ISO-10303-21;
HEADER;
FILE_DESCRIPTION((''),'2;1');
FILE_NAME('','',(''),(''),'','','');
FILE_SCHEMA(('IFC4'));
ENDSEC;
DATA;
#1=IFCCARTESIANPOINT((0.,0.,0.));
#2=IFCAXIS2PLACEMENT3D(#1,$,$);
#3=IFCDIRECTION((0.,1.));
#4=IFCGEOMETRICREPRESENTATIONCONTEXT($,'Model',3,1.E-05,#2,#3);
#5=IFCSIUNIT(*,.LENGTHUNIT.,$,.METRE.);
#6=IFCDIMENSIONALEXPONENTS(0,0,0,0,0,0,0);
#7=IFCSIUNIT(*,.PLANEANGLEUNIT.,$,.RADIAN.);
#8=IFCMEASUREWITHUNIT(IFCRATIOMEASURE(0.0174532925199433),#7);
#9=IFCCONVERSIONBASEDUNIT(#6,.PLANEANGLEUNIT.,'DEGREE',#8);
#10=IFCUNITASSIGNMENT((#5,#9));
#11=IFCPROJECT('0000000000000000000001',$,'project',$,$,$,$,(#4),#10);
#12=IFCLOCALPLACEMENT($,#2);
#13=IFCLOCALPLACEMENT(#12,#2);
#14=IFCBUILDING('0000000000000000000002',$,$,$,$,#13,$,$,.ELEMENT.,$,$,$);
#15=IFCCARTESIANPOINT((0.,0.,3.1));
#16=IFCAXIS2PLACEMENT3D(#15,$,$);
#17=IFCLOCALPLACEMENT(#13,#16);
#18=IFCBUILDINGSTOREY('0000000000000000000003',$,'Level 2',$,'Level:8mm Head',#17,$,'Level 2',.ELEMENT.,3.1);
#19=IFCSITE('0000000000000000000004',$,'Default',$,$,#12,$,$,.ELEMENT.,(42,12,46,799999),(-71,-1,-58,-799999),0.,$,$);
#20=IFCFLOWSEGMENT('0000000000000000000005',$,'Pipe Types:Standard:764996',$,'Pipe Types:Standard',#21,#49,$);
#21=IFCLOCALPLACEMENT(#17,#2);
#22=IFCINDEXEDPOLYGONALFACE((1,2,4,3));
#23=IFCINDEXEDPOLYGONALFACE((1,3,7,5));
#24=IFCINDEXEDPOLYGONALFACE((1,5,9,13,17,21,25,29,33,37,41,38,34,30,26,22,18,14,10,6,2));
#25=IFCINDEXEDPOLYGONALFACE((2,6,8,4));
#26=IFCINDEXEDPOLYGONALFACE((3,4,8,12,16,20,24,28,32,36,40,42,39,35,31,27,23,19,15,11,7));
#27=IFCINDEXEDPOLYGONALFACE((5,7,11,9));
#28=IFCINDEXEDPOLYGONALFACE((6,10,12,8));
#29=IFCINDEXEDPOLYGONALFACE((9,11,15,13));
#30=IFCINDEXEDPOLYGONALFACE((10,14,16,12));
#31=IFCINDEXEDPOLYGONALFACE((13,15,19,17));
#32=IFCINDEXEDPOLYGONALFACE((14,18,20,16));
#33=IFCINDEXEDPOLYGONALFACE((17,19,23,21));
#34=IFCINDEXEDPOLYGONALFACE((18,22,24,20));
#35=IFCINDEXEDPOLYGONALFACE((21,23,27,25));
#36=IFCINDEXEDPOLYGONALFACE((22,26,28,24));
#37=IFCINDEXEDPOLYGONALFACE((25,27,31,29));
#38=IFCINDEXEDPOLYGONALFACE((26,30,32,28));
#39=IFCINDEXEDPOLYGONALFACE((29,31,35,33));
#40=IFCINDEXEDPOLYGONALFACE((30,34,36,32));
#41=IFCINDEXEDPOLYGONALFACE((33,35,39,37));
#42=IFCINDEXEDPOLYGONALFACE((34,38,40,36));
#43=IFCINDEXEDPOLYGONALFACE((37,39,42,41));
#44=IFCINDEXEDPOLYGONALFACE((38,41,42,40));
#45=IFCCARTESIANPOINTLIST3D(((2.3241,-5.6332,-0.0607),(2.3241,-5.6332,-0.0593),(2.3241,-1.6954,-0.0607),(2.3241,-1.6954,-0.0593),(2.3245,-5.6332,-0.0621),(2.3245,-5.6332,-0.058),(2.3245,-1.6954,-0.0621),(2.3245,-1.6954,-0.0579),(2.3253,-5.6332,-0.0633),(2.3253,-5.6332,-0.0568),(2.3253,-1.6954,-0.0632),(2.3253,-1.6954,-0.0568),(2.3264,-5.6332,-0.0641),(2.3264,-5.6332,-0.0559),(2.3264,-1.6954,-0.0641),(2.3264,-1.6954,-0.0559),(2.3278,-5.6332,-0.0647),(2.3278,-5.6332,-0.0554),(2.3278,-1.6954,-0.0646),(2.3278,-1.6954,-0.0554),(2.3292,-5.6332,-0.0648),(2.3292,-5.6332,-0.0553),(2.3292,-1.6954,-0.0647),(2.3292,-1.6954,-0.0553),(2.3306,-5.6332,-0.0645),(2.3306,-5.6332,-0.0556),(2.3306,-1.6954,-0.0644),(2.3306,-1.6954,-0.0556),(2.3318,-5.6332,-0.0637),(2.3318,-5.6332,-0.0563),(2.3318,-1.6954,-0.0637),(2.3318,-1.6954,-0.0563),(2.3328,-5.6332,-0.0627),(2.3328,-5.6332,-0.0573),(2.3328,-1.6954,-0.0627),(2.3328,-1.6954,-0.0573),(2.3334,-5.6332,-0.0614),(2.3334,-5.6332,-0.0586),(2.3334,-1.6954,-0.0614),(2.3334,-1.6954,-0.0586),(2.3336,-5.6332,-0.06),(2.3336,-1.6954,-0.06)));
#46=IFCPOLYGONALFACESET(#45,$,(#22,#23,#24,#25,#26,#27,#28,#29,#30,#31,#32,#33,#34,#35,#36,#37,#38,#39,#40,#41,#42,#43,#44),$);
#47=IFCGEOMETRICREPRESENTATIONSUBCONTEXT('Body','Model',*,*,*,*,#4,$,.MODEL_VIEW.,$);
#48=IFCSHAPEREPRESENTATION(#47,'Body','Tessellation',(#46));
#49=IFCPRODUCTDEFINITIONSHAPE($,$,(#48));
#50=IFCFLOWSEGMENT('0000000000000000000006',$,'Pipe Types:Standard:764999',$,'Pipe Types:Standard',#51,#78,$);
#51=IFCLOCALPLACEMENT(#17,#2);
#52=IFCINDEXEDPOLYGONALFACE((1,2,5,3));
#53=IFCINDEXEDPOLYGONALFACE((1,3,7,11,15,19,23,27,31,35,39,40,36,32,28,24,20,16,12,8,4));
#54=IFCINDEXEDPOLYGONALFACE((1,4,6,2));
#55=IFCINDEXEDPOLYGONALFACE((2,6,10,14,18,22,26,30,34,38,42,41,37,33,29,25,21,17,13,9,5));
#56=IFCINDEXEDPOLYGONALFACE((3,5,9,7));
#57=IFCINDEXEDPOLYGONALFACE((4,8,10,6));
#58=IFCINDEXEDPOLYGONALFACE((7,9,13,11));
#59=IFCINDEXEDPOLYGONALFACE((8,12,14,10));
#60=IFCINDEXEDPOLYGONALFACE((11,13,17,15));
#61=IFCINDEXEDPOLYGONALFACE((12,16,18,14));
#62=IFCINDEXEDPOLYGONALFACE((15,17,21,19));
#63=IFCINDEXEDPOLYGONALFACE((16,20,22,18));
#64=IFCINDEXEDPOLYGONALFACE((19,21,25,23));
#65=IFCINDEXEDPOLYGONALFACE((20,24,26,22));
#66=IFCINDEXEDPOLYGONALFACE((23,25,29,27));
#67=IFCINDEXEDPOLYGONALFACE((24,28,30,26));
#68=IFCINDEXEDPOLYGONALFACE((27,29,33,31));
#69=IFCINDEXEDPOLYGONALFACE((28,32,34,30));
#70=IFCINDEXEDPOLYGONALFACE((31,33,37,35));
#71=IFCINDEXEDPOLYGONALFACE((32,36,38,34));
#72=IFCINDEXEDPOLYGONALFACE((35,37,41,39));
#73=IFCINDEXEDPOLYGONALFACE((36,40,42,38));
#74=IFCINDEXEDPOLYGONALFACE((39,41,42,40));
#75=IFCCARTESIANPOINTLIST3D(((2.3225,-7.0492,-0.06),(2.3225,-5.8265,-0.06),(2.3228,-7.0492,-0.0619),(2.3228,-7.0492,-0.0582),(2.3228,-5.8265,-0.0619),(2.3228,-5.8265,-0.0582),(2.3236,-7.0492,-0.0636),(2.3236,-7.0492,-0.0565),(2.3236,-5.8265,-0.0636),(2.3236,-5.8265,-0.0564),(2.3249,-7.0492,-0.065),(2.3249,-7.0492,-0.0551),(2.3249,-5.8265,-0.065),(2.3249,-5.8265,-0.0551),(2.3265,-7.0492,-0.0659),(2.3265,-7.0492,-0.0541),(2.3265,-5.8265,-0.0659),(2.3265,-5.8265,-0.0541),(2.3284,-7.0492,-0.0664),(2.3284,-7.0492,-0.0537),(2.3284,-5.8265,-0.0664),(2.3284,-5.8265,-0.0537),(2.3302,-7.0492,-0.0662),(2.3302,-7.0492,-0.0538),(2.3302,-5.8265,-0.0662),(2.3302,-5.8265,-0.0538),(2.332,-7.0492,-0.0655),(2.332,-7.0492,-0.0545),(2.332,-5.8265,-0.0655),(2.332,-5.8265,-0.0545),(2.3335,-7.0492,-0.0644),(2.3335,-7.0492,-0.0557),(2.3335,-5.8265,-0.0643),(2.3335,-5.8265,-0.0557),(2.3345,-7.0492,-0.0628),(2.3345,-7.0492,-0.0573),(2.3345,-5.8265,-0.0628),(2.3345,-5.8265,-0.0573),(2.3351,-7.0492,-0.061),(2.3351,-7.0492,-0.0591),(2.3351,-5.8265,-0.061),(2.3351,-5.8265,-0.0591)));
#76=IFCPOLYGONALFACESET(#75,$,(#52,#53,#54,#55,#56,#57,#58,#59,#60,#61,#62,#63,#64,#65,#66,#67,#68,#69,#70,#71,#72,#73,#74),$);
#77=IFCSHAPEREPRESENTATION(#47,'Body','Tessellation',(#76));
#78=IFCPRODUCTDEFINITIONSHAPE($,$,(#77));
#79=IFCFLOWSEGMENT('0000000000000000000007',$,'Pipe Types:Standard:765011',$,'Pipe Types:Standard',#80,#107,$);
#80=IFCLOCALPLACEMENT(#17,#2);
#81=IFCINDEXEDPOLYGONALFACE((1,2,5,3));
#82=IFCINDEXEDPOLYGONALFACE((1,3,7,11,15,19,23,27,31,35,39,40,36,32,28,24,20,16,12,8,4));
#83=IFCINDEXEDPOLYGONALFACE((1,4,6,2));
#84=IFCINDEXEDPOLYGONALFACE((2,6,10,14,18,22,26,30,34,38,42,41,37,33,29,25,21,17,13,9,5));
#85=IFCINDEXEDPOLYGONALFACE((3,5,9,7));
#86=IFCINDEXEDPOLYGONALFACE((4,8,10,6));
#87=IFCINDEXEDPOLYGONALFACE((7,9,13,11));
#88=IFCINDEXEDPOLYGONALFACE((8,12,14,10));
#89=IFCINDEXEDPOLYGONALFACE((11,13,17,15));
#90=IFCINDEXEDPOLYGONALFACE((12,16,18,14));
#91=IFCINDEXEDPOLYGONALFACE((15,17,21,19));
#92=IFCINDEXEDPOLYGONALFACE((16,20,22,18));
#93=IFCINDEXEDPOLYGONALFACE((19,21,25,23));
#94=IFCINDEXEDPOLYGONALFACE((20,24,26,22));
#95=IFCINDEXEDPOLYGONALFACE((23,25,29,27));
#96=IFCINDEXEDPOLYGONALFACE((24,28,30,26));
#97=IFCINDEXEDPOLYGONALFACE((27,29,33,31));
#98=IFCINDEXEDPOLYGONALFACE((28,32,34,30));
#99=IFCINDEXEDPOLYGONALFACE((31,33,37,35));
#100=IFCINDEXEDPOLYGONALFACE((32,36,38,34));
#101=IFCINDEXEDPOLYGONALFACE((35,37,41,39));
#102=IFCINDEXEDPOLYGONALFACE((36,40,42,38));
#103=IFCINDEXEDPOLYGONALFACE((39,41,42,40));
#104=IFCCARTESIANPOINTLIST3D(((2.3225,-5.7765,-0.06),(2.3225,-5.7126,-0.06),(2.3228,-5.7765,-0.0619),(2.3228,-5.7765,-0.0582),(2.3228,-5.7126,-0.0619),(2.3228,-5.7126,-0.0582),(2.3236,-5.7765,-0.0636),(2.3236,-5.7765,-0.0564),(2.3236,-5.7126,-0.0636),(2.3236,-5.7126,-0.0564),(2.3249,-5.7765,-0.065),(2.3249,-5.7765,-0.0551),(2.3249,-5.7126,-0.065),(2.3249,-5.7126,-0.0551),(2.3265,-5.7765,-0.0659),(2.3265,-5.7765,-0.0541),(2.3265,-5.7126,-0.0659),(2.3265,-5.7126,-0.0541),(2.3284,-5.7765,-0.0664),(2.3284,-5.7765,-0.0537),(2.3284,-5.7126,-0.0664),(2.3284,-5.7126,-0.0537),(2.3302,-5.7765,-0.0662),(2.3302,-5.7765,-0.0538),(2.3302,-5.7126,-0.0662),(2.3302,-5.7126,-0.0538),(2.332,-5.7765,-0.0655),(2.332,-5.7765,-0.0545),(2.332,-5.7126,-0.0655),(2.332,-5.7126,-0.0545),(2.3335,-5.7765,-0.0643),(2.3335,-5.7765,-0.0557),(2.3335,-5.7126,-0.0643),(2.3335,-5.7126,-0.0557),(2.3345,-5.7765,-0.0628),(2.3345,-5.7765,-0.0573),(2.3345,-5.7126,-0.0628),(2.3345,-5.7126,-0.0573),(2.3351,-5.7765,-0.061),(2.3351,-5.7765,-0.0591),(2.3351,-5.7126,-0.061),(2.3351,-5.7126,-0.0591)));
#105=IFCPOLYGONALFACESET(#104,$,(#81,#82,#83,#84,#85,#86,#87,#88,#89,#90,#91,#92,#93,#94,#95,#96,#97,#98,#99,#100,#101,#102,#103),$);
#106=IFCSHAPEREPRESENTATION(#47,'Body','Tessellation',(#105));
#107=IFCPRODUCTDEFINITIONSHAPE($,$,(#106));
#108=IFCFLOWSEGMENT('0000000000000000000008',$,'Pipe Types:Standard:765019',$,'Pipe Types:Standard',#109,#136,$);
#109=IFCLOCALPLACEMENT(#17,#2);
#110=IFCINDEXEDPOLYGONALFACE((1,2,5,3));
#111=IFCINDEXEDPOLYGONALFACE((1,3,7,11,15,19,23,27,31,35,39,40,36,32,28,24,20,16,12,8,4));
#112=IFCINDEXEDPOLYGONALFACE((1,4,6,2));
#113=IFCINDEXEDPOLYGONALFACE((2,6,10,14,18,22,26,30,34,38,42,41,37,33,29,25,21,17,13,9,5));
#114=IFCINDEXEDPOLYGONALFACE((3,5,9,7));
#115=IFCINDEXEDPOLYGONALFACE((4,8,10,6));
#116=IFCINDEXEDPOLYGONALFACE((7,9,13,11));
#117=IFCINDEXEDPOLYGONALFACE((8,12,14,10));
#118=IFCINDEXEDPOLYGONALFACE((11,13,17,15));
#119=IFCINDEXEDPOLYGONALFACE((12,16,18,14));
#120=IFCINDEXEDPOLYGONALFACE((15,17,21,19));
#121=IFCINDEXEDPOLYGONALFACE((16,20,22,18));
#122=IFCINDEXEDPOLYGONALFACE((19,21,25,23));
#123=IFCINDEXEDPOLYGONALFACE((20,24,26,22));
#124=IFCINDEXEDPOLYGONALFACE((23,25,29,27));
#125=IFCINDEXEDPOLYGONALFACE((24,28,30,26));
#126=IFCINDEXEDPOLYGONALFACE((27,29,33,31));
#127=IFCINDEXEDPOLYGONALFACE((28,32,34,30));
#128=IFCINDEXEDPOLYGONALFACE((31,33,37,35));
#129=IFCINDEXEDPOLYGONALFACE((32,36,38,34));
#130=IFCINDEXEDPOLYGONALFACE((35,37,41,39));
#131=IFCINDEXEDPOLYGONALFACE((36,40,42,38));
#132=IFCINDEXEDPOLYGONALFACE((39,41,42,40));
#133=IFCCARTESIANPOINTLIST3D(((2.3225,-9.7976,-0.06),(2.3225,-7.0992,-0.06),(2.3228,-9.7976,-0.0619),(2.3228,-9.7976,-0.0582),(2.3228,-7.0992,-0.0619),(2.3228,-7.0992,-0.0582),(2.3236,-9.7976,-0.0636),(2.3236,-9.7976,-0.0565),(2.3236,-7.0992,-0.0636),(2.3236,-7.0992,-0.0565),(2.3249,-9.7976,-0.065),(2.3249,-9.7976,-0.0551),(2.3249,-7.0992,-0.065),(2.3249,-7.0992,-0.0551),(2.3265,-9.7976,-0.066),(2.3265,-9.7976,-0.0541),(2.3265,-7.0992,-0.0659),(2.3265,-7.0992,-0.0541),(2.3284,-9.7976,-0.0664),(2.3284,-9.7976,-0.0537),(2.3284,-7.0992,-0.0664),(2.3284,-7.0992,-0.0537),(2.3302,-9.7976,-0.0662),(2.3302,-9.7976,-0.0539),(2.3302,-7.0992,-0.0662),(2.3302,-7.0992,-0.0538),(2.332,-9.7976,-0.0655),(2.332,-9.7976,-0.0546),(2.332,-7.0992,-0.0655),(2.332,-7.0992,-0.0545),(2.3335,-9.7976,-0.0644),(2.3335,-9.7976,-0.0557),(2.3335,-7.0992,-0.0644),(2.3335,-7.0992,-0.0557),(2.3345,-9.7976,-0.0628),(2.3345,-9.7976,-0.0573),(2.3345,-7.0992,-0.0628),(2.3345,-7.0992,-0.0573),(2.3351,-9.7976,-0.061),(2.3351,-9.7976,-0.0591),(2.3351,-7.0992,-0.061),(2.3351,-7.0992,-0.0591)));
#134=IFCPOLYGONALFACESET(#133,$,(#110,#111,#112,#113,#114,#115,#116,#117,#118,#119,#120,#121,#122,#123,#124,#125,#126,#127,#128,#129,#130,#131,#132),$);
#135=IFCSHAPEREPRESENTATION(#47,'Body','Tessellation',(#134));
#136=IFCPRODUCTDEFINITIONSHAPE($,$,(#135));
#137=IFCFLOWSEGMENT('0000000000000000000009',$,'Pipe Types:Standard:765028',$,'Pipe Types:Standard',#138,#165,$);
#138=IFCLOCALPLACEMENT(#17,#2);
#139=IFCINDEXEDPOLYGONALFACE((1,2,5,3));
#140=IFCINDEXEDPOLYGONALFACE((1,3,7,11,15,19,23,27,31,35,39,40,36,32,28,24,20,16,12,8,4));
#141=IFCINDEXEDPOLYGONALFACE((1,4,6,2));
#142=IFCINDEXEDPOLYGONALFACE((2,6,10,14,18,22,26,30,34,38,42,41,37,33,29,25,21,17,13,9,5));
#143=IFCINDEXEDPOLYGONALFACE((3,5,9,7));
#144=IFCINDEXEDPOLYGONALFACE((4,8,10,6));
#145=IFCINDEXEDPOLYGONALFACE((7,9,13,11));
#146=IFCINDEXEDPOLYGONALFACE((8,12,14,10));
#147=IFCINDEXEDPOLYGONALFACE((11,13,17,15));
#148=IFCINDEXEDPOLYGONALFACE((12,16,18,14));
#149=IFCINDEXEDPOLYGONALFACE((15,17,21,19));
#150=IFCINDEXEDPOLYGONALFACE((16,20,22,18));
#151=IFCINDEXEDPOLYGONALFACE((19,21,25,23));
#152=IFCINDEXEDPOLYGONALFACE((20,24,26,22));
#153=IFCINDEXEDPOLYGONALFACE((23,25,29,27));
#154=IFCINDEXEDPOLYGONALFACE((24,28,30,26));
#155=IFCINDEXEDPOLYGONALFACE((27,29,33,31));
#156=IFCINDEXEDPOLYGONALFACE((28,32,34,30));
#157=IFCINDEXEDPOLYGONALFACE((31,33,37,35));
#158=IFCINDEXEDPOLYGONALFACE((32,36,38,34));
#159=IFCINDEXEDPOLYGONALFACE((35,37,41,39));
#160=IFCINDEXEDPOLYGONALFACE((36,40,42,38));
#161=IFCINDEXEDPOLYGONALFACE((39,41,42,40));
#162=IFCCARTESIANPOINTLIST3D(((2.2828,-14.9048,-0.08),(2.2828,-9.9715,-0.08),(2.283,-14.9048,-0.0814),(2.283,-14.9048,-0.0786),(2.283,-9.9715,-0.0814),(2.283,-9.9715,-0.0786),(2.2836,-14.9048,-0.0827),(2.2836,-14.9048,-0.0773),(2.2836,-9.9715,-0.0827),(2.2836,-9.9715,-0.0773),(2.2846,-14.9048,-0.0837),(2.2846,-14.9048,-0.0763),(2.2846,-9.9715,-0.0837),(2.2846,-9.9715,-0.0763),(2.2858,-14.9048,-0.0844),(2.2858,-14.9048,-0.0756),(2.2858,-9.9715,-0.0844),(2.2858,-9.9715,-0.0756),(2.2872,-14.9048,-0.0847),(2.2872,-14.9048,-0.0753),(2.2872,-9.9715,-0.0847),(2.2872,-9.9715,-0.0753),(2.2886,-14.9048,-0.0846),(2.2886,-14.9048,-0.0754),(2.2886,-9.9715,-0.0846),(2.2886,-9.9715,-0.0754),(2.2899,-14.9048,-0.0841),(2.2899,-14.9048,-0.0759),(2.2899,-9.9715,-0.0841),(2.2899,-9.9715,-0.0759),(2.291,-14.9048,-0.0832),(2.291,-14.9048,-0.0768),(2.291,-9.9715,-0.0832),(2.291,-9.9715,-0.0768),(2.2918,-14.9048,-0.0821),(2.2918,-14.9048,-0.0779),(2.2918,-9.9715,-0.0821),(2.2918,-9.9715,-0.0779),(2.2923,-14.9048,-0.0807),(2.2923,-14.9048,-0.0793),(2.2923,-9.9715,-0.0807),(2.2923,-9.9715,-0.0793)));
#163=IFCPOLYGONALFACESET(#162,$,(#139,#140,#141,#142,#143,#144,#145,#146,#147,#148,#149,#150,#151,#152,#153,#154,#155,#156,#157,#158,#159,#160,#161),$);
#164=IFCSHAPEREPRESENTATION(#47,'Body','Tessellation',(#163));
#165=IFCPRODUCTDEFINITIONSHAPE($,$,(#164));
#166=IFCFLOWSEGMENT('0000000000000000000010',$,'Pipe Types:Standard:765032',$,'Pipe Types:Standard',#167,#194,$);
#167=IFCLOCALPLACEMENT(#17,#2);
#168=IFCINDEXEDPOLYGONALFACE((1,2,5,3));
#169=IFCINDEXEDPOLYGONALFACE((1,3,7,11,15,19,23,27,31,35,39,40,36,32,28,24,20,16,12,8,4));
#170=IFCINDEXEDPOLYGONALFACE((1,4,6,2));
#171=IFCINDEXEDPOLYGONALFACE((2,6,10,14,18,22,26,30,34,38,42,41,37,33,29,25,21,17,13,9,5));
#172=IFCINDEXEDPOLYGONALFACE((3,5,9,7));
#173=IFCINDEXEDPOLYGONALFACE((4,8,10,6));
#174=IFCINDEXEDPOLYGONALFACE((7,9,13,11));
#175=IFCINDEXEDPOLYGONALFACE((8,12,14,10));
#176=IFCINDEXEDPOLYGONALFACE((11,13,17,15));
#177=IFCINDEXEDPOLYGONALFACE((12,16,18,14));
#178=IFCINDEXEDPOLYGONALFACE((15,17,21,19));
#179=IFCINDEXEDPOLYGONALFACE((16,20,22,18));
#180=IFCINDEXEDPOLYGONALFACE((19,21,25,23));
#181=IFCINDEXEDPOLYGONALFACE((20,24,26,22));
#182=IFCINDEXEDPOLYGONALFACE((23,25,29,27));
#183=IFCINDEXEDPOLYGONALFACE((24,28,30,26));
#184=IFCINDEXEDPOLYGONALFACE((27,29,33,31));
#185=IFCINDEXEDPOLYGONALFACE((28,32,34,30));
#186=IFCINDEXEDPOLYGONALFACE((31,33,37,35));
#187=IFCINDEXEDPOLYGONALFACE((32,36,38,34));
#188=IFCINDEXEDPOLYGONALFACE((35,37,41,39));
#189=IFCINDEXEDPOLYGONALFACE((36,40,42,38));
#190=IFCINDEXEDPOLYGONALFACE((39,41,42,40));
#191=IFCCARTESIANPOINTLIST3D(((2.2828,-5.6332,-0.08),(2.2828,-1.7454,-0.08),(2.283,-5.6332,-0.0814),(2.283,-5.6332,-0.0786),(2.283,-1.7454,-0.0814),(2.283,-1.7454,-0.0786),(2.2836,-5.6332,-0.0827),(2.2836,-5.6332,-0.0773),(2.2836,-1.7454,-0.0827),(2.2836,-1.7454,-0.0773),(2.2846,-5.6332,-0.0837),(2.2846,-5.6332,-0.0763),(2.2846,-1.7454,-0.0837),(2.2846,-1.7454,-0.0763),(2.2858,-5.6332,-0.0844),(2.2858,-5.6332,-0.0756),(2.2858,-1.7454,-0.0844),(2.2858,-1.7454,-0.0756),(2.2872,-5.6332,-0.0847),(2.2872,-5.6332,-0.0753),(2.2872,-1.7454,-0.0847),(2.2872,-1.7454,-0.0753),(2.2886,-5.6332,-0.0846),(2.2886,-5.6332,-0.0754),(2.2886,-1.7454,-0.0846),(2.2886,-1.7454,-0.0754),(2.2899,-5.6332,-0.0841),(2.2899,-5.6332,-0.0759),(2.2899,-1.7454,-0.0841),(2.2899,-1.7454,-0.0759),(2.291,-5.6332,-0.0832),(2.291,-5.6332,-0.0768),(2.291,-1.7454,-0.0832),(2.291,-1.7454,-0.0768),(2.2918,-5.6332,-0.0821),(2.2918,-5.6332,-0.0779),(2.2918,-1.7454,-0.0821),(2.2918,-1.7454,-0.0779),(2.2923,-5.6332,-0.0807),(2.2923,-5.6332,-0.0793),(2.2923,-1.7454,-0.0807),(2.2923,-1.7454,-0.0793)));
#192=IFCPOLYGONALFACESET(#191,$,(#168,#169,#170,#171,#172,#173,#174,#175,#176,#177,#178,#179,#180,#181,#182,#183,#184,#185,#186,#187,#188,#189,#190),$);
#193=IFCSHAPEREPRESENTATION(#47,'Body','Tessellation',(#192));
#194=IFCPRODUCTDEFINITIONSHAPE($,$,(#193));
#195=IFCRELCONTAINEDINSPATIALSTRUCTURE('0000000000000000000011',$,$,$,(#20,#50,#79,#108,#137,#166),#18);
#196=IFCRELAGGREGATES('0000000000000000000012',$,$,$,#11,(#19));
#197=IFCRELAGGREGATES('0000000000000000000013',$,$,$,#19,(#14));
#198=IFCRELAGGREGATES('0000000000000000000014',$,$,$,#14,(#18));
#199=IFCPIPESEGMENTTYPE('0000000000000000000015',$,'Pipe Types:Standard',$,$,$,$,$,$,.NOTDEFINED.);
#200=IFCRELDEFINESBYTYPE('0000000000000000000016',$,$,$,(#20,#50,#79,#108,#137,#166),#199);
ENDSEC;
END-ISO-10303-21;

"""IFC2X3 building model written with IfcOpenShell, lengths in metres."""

from ifc_helpers import new_model, entity, si_unit, converted_unit, direction, frame, frame_2d, origin, origin_2d_with_axis, place, context, subcontext, project, spatial, circle, extrude, type_object, element, save


model = new_model("IFC2X3")

# Units and contexts
model_context = context("Model", 3, precision=1e-05, world=origin(), true_north=direction((0.0, 1.0)))
body_context = subcontext(model_context, "Body", "Model", "MODEL_VIEW")
ifc_project = project(units=[si_unit("LENGTHUNIT", "METRE"), converted_unit("PLANEANGLEUNIT", "DEGREE", entity("IfcRatioMeasure", 0.0174532925199433), si_unit("PLANEANGLEUNIT", "RADIAN"), dimensions=[0, 0, 0, 0, 0, 0, 0])], contexts=[model_context])

# Site, building, storey
site_placement = place(None, origin())
site = spatial("IfcSite", under=ifc_project, at=site_placement, Name="Default", CompositionType="ELEMENT", RefLatitude=(42, 12, 46, 799999), RefLongitude=(-71, -1, -58, -799999), RefElevation=0.0)
building_placement = place(site_placement, origin())
building = spatial("IfcBuilding", under=site, at=building_placement, CompositionType="ELEMENT")
storey_placement = place(building_placement, frame((0.0, 0.0, 3.1)))
storey = spatial("IfcBuildingStorey", under=building, at=storey_placement, Name="Level 2", ObjectType="Level:8mm Head", LongName="Level 2", CompositionType="ELEMENT", Elevation=3.1)

# Flow segments
pipe_segment_type = type_object("IfcPipeSegmentType", Name="Pipe Types:Standard", PredefinedType="NOTDEFINED")
flow_segment_1_placement = place(storey_placement, origin())
element("IfcFlowSegment", 1, at=flow_segment_1_placement, inside=storey, type_object=pipe_segment_type, Name="Pipe Types:Standard:764996", ObjectType="Pipe Types:Standard", context=body_context, shape_type="SweptSolid", body=[
    extrude(circle(Radius=0.0048, at=origin_2d_with_axis()), frame((2.3288, -5.6332, -0.06), z_axis=(0.0, 1.0, 0.000006), x_axis=(1.0, 0.0, 0.0)), (0.0, 0.0, 1.0), 3.9377),
])
flow_segment_2_placement = place(storey_placement, origin())
element("IfcFlowSegment", 2, at=flow_segment_2_placement, inside=storey, type_object=pipe_segment_type, Name="Pipe Types:Standard:764999", ObjectType="Pipe Types:Standard", context=body_context, shape_type="SweptSolid", body=[
    extrude(circle(Radius=0.0063, at=origin_2d_with_axis()), frame((2.3288, -7.0492, -0.06), z_axis=(0.0, 1.0, 0.000005), x_axis=(-1.0, 0.0, 0.0)), (0.0, 0.0, 1.0), 1.2227),
])
flow_segment_3_placement = place(storey_placement, origin())
element("IfcFlowSegment", 3, at=flow_segment_3_placement, inside=storey, type_object=pipe_segment_type, Name="Pipe Types:Standard:765011", ObjectType="Pipe Types:Standard", context=body_context, shape_type="SweptSolid", body=[
    extrude(circle(Radius=0.0063, at=frame_2d((0.0, 0.0), x_axis=(1.0, 0.0))), frame((2.3288, -5.7765, -0.06), z_axis=(0.0, 1.0, 0.0), x_axis=(-1.0, 0.0, 0.0)), (0.0, 0.0, 1.0), 0.0639),
])
flow_segment_4_placement = place(storey_placement, origin())
element("IfcFlowSegment", 4, at=flow_segment_4_placement, inside=storey, type_object=pipe_segment_type, Name="Pipe Types:Standard:765019", ObjectType="Pipe Types:Standard", context=body_context, shape_type="SweptSolid", body=[
    extrude(circle(Radius=0.0063, at=frame_2d((0.0, 0.0), x_axis=(1.0, 0.0))), frame((2.3288, -9.7976, -0.06), z_axis=(0.0, 1.0, 0.000006), x_axis=(-1.0, 0.0, 0.0)), (0.0, 0.0, 1.0), 2.6985),
])
flow_segment_5_placement = place(storey_placement, origin())
element("IfcFlowSegment", 5, at=flow_segment_5_placement, inside=storey, type_object=pipe_segment_type, Name="Pipe Types:Standard:765028", ObjectType="Pipe Types:Standard", context=body_context, shape_type="SweptSolid", body=[
    extrude(circle(Radius=0.0048, at=frame_2d((0.0, 0.0), x_axis=(1.0, 0.0))), frame((2.2875, -14.9048, -0.08), z_axis=(0.0, 1.0, 0.0), x_axis=(-1.0, 0.0, 0.0)), (0.0, 0.0, 1.0), 4.9333),
])
flow_segment_6_placement = place(storey_placement, origin())
element("IfcFlowSegment", 6, at=flow_segment_6_placement, inside=storey, type_object=pipe_segment_type, Name="Pipe Types:Standard:765032", ObjectType="Pipe Types:Standard", context=body_context, shape_type="SweptSolid", body=[
    extrude(circle(Radius=0.0048, at=frame_2d((0.0, 0.0), x_axis=(1.0, 0.0))), frame((2.2875, -5.6332, -0.08), z_axis=(0.0, 1.0, 0.0), x_axis=(-1.0, 0.0, 0.0)), (0.0, 0.0, 1.0), 3.8877),
])

save(model, "model.ifc")
